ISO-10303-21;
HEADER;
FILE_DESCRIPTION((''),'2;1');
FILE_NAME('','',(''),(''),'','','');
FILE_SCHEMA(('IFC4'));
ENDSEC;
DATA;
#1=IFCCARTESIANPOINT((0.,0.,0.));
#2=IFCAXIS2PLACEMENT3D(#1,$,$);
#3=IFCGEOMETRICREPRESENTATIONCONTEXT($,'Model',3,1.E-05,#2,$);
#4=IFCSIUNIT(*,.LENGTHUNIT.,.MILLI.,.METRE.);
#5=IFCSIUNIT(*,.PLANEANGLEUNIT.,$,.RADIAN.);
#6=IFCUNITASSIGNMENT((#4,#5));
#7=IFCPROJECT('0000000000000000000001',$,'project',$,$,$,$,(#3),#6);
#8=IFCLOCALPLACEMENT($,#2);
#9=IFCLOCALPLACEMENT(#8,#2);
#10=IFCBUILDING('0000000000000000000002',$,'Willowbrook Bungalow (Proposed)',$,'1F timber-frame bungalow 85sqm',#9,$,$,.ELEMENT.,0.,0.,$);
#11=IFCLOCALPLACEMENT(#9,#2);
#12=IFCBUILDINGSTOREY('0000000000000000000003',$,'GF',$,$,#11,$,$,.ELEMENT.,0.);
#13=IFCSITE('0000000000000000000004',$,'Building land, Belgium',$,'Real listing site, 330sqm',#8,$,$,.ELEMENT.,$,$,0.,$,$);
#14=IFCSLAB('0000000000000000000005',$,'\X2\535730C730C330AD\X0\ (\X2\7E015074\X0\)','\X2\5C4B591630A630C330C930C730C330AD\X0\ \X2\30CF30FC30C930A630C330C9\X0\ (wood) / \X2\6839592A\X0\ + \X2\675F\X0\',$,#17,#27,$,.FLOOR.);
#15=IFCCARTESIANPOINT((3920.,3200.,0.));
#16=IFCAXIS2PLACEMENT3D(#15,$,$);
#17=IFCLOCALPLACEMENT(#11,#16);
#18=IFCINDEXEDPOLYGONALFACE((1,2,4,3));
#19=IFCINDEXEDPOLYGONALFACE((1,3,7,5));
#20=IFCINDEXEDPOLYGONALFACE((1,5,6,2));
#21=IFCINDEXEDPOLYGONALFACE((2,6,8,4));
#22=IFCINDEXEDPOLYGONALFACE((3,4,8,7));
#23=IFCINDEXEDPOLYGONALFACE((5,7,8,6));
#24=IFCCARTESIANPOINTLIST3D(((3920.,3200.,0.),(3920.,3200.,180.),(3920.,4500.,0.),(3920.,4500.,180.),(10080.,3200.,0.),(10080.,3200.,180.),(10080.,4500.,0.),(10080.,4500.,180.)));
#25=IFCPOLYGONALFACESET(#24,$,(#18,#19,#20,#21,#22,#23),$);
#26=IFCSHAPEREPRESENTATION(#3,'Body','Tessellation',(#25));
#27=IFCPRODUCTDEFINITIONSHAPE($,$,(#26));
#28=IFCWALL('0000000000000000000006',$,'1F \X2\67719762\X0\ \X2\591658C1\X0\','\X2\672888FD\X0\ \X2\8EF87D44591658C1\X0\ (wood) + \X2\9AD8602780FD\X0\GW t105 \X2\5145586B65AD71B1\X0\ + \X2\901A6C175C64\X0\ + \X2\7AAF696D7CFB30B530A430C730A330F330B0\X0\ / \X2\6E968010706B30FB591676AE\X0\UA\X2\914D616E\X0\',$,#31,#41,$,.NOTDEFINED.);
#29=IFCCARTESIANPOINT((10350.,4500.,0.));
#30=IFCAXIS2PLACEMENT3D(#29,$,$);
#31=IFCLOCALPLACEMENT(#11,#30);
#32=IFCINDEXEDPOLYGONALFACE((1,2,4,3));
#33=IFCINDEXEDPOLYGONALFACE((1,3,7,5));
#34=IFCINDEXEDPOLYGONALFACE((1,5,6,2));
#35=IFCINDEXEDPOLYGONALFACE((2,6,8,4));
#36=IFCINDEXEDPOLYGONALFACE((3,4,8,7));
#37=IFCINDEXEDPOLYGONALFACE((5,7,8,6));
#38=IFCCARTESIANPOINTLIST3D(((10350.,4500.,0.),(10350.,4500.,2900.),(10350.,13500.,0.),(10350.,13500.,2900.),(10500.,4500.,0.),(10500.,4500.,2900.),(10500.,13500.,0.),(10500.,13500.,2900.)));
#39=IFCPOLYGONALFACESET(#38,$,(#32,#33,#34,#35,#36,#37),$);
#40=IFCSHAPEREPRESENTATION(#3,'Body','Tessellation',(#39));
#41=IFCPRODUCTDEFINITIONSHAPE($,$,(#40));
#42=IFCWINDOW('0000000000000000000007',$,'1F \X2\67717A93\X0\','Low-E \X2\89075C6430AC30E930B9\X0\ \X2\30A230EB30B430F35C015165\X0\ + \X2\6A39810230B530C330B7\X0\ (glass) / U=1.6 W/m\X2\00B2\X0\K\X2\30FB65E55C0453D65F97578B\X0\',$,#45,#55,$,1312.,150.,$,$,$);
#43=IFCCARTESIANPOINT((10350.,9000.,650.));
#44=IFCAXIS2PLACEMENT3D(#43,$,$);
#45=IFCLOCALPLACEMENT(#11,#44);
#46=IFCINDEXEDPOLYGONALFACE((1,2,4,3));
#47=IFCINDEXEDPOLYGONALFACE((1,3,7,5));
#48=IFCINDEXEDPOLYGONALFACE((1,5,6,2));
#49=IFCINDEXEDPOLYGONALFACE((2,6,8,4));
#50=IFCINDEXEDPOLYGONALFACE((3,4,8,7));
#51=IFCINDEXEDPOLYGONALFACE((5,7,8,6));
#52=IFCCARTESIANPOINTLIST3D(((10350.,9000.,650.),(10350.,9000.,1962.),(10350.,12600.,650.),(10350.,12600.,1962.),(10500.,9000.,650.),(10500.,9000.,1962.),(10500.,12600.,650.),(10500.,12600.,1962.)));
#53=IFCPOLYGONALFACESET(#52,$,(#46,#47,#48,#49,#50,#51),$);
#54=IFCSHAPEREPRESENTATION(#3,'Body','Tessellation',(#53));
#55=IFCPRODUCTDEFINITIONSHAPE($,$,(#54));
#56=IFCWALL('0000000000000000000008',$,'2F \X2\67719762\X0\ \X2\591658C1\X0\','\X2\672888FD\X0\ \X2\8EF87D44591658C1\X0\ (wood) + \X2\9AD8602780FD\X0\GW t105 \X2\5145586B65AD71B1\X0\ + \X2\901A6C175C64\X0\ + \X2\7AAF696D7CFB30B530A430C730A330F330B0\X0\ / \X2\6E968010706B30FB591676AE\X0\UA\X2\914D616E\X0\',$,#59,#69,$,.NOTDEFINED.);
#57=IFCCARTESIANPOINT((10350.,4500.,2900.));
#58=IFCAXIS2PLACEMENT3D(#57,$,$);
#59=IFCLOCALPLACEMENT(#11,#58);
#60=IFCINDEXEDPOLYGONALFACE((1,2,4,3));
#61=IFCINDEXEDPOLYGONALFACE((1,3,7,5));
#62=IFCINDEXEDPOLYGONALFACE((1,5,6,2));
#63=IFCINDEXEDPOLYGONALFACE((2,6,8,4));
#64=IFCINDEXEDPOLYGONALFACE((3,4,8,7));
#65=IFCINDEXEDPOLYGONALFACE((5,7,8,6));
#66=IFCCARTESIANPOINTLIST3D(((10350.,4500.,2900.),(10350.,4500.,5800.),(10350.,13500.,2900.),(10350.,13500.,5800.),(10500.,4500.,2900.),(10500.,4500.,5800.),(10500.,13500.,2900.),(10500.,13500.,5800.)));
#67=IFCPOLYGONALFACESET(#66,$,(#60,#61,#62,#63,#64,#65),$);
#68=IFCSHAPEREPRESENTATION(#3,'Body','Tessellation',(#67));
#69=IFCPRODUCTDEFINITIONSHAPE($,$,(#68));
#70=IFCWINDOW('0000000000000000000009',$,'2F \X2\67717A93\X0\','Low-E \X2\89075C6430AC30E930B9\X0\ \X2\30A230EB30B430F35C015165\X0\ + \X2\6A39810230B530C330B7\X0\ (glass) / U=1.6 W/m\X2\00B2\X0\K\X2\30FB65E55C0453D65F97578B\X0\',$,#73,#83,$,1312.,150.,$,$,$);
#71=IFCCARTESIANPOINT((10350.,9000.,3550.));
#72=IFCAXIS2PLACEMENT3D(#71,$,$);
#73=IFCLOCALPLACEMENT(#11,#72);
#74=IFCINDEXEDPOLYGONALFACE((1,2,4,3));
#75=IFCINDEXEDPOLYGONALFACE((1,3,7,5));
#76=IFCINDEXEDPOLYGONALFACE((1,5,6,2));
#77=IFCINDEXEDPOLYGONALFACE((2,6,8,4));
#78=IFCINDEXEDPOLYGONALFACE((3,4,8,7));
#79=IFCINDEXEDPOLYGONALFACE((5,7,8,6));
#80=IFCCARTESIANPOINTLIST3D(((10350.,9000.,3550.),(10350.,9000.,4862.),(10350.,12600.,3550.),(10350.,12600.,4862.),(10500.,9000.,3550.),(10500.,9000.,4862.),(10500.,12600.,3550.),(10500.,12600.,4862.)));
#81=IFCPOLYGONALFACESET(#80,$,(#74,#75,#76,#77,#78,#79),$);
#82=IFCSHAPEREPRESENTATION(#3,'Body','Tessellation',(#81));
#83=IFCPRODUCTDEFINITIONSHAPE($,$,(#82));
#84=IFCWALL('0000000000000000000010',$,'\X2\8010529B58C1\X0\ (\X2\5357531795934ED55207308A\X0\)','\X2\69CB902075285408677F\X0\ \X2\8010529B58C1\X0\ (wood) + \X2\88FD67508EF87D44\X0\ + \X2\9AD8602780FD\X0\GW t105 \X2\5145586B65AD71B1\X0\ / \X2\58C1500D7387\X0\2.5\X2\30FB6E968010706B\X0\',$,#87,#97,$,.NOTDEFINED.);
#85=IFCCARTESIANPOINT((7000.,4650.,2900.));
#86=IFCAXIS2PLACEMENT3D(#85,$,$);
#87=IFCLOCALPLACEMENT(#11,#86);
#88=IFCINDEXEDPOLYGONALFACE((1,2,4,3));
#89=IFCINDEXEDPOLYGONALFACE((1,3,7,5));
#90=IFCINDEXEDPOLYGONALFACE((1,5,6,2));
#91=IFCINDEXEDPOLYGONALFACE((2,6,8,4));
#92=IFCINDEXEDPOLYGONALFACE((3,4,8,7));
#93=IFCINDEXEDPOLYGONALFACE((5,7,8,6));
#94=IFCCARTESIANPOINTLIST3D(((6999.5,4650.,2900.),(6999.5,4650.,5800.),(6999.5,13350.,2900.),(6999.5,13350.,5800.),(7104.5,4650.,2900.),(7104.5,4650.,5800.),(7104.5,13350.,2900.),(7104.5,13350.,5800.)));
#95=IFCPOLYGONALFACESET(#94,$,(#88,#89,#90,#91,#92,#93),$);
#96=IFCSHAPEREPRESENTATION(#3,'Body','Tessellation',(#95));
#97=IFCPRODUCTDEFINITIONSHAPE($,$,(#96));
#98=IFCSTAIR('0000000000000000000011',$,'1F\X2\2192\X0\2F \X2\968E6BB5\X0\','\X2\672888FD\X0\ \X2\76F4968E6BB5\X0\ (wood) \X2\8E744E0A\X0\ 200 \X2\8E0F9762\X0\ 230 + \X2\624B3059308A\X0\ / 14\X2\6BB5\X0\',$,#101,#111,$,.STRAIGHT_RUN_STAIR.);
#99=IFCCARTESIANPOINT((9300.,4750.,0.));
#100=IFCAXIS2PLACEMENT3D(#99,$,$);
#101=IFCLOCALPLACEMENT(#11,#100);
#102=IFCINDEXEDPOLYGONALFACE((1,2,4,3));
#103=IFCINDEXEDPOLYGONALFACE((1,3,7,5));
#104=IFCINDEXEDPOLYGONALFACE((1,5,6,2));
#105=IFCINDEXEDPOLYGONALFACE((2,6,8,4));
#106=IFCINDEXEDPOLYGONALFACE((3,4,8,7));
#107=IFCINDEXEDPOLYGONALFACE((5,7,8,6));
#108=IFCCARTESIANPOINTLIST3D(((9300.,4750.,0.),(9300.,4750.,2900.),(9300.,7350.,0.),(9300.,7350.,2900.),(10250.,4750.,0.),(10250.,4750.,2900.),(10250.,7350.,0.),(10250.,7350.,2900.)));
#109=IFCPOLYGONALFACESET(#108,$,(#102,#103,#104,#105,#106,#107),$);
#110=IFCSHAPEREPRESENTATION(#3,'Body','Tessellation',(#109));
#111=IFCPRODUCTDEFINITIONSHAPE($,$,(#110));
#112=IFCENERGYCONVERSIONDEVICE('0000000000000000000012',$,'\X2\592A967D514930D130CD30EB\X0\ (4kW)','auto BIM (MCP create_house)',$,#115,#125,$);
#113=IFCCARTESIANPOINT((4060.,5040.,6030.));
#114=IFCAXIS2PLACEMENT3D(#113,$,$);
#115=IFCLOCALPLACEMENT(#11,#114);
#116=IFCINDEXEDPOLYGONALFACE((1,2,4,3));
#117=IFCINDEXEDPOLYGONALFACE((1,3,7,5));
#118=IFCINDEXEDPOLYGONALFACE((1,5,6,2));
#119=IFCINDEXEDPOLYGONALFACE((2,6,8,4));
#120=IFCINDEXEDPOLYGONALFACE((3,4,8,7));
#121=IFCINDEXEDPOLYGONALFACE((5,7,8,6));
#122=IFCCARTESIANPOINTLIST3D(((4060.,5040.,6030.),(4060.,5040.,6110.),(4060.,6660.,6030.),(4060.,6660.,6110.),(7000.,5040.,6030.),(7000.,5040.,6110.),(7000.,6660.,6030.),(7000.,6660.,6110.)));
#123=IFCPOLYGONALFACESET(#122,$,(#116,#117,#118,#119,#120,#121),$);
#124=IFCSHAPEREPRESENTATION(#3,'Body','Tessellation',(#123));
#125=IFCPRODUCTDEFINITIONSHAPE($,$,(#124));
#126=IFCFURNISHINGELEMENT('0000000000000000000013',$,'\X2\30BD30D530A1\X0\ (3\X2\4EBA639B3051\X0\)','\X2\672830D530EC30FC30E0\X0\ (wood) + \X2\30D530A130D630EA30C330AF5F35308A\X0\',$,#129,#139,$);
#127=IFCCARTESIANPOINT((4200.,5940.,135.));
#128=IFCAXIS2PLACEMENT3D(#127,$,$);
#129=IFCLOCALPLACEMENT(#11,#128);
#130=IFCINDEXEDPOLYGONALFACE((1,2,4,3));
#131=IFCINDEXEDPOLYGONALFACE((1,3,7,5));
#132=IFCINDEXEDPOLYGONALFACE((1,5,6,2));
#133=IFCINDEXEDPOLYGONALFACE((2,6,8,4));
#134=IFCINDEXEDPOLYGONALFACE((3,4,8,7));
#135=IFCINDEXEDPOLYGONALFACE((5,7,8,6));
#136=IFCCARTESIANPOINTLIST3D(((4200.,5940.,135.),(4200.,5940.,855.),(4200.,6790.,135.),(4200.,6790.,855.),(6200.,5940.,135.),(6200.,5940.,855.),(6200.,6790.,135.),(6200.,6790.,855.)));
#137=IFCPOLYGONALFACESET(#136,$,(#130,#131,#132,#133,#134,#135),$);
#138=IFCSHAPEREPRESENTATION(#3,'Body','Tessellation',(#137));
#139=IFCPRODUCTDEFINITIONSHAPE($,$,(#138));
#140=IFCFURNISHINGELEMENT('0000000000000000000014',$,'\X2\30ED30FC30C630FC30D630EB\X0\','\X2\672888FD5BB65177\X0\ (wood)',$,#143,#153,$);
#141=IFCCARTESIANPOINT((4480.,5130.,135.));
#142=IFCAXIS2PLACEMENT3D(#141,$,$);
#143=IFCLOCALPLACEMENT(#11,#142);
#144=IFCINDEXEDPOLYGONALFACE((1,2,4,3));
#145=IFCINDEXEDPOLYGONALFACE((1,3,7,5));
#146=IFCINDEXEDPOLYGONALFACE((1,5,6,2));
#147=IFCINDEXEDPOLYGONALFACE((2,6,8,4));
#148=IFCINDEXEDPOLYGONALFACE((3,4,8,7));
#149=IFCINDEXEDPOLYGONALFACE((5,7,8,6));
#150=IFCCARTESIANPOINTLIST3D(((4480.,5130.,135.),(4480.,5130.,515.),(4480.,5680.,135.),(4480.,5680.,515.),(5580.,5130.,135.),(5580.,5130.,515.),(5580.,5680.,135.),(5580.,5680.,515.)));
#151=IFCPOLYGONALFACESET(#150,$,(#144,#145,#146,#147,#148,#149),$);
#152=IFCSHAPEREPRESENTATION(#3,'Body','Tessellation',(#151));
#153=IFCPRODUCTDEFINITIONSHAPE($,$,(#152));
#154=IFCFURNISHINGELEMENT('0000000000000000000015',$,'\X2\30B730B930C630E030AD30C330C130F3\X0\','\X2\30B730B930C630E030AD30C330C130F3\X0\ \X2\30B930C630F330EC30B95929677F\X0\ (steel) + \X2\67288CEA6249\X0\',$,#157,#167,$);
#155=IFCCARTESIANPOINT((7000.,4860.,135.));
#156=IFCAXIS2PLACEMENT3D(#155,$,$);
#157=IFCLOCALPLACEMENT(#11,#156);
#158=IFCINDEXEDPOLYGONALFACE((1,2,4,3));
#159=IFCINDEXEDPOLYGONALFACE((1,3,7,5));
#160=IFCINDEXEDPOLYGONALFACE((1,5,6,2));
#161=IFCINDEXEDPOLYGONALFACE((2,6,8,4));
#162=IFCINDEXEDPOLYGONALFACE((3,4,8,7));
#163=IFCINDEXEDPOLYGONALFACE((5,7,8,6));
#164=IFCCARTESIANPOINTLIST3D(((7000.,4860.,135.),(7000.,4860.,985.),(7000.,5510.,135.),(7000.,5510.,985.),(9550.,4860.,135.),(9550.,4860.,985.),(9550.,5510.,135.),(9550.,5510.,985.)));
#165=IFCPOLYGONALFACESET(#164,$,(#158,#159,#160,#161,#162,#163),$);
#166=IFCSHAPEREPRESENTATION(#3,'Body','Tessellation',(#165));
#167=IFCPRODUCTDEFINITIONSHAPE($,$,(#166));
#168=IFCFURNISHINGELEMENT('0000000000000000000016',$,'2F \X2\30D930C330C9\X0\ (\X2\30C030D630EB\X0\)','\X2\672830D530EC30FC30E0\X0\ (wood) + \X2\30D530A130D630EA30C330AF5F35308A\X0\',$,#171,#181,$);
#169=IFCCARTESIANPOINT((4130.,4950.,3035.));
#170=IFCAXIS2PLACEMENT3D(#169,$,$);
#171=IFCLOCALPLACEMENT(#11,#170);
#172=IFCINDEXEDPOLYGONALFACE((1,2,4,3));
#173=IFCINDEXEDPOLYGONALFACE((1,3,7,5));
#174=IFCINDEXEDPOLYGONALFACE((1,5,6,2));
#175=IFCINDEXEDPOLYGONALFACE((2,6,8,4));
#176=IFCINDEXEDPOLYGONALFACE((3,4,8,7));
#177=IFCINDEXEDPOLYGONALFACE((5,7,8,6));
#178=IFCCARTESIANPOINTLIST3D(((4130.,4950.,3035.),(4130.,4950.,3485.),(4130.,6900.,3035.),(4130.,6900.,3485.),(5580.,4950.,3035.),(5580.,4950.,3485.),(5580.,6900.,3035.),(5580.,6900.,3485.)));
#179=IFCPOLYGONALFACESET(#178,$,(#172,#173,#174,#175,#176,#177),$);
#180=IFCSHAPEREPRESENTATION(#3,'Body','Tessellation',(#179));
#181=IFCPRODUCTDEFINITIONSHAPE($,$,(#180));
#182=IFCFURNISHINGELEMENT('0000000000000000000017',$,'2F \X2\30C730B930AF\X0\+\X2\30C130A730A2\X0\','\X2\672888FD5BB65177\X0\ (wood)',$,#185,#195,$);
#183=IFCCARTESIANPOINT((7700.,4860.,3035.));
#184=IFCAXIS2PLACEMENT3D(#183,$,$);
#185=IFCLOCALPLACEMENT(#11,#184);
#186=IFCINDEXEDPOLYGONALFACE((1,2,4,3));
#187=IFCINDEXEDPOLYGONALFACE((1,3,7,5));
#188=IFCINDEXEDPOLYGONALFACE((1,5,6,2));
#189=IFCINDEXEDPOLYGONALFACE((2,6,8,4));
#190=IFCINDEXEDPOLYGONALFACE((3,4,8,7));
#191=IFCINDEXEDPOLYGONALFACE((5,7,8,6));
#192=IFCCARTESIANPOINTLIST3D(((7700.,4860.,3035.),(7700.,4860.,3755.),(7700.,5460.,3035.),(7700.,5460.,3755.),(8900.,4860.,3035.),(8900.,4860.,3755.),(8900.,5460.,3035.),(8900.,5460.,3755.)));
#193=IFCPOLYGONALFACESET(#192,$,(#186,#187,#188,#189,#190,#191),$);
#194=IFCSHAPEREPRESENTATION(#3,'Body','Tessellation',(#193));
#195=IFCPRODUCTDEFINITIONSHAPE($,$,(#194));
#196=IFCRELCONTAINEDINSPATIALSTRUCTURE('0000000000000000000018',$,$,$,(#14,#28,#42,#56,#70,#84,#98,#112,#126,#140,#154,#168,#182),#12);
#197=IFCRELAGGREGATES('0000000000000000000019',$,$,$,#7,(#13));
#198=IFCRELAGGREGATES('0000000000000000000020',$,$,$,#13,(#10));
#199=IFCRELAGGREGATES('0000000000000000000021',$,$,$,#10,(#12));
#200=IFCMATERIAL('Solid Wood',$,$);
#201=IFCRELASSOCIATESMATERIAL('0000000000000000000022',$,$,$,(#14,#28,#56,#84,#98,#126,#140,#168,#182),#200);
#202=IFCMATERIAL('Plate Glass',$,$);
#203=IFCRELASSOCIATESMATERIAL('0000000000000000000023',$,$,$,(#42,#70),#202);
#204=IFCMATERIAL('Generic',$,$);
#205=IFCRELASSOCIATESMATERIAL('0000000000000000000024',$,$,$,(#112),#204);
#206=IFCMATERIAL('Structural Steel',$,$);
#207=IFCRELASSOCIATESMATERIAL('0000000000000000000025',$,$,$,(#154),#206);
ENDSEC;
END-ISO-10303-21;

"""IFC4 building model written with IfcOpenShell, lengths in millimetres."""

from ifc_helpers import new_model, si_unit, frame, frame_2d, origin, place, context, project, spatial, rectangle, extrude, material, element, fill, save


model = new_model("IFC4")

# Units and contexts
model_context = context("Model", 3, precision=1e-05, world=origin())
ifc_project = project(units=[si_unit("LENGTHUNIT", "METRE", prefix="MILLI"), si_unit("PLANEANGLEUNIT", "RADIAN")], contexts=[model_context])

# Site, building, storey
site_placement = place(None, origin())
site = spatial("IfcSite", under=ifc_project, at=site_placement, Name="Building land, Belgium", ObjectType="Real listing site, 330sqm", CompositionType="ELEMENT", RefElevation=0.0)
building_placement = place(site_placement, origin())
building = spatial("IfcBuilding", under=site, at=building_placement, Name="Willowbrook Bungalow (Proposed)", ObjectType="1F timber-frame bungalow 85sqm", CompositionType="ELEMENT", ElevationOfRefHeight=0.0, ElevationOfTerrain=0.0)
storey_placement = place(building_placement, origin())
storey = spatial("IfcBuildingStorey", under=building, at=storey_placement, Name="GF", CompositionType="ELEMENT", Elevation=0.0)

# Slab
ifc_material_1 = material(Name="Solid Wood")
slab_placement = place(storey_placement, frame((3920.0, 3200.0, 0.0)))
element("IfcSlab", 1, at=slab_placement, inside=storey, material=ifc_material_1, Name="南デッキ (縁側)", Description="屋外ウッドデッキ ハードウッド (wood) / 根太 + 束", PredefinedType="FLOOR", context=model_context, shape_type="SweptSolid", body=[
    extrude(rectangle(XDim=6160.0, YDim=1300.0, at=frame_2d((3080.0, 650.0))), frame((3920.0, 3200.0, 0.0)), (0.0, 0.0, 1.0), 180.0),
])

# Wall, opening, window
wall_1_placement = place(storey_placement, frame((10350.0, 4500.0, 0.0)))
wall_1 = element("IfcWall", 2, at=wall_1_placement, inside=storey, material=ifc_material_1, Name="1F 東面 外壁", Description="木製 軸組外壁 (wood) + 高性能GW t105 充填断熱 + 通気層 + 窯業系サイディング / 準耐火・外皮UA配慮", PredefinedType="NOTDEFINED", context=model_context, shape_type="SweptSolid", body=[
    extrude(rectangle(XDim=150.0, YDim=9000.0, at=frame_2d((75.0, 4500.0))), frame((10350.0, 4500.0, 0.0)), (0.0, 0.0, 1.0), 2900.0),
])
opening_1_placement = place(storey_placement, frame((10350.0, 9000.0, 650.0)))
opening_1 = element("IfcOpeningElement", 3, at=opening_1_placement, cuts=wall_1, PredefinedType="NOTDEFINED", context=model_context, shape_type="SweptSolid", body=[
    extrude(rectangle(XDim=150.0, YDim=3600.0, at=frame_2d((75.0, 1800.0))), frame((10350.0, 9000.0, 650.0)), (0.0, 0.0, 1.0), 1312.0),
])
ifc_material_2 = material(Name="Plate Glass")
window_1_placement = place(storey_placement, frame((10350.0, 9000.0, 650.0)))
window_1 = element("IfcWindow", 4, at=window_1_placement, inside=storey, material=ifc_material_2, Name="1F 東窓", Description="Low-E 複層ガラス アルゴン封入 + 樹脂サッシ (glass) / U=1.6 W/m²K・日射取得型", OverallHeight=1312.0, OverallWidth=150.0, context=model_context, shape_type="SweptSolid", body=[
    extrude(rectangle(XDim=150.0, YDim=3600.0, at=frame_2d((75.0, 1800.0))), frame((10350.0, 9000.0, 650.0)), (0.0, 0.0, 1.0), 1312.0),
])
fill(opening_1, window_1)

# Wall, opening, window
wall_2_placement = place(storey_placement, frame((10350.0, 4500.0, 2900.0)))
wall_2 = element("IfcWall", 5, at=wall_2_placement, inside=storey, material=ifc_material_1, Name="2F 東面 外壁", Description="木製 軸組外壁 (wood) + 高性能GW t105 充填断熱 + 通気層 + 窯業系サイディング / 準耐火・外皮UA配慮", PredefinedType="NOTDEFINED", context=model_context, shape_type="SweptSolid", body=[
    extrude(rectangle(XDim=150.0, YDim=9000.0, at=frame_2d((75.0, 4500.0))), frame((10350.0, 4500.0, 2900.0)), (0.0, 0.0, 1.0), 2900.0),
])
opening_2_placement = place(storey_placement, frame((10350.0, 9000.0, 3550.0)))
opening_2 = element("IfcOpeningElement", 6, at=opening_2_placement, cuts=wall_2, PredefinedType="NOTDEFINED", context=model_context, shape_type="SweptSolid", body=[
    extrude(rectangle(XDim=150.0, YDim=3600.0, at=frame_2d((75.0, 1800.0))), frame((10350.0, 9000.0, 3550.0)), (0.0, 0.0, 1.0), 1312.0),
])
window_2_placement = place(storey_placement, frame((10350.0, 9000.0, 3550.0)))
window_2 = element("IfcWindow", 7, at=window_2_placement, inside=storey, material=ifc_material_2, Name="2F 東窓", Description="Low-E 複層ガラス アルゴン封入 + 樹脂サッシ (glass) / U=1.6 W/m²K・日射取得型", OverallHeight=1312.0, OverallWidth=150.0, context=model_context, shape_type="SweptSolid", body=[
    extrude(rectangle(XDim=150.0, YDim=3600.0, at=frame_2d((75.0, 1800.0))), frame((10350.0, 9000.0, 3550.0)), (0.0, 0.0, 1.0), 1312.0),
])
fill(opening_2, window_2)

# Wall
wall_3_placement = place(storey_placement, frame((7000.0, 4650.0, 2900.0)))
element("IfcWall", 8, at=wall_3_placement, inside=storey, material=ifc_material_1, Name="耐力壁 (南北間仕切り)", Description="構造用合板 耐力壁 (wood) + 製材軸組 + 高性能GW t105 充填断熱 / 壁倍率2.5・準耐火", PredefinedType="NOTDEFINED", context=model_context, shape_type="SweptSolid", body=[
    extrude(rectangle(XDim=105.0, YDim=8700.0, at=frame_2d((52.0, 4350.0))), frame((7000.0, 4650.0, 2900.0)), (0.0, 0.0, 1.0), 2900.0),
])

# Stair
stair_placement = place(storey_placement, frame((9300.0, 4750.0, 0.0)))
element("IfcStair", 9, at=stair_placement, inside=storey, material=ifc_material_1, Name="1F→2F 階段", Description="木製 直階段 (wood) 蹴上 200 踏面 230 + 手すり / 14段", PredefinedType="STRAIGHT_RUN_STAIR", context=model_context, shape_type="SweptSolid", body=[
    extrude(rectangle(XDim=950.0, YDim=2600.0, at=frame_2d((475.0, 1300.0))), frame((9300.0, 4750.0, 0.0)), (0.0, 0.0, 1.0), 2900.0),
])

# Energy conversion device
ifc_material_3 = material(Name="Generic")
energy_conversion_device_placement = place(storey_placement, frame((4060.0, 5040.0, 6030.0)))
element("IfcEnergyConversionDevice", 10, at=energy_conversion_device_placement, inside=storey, material=ifc_material_3, Name="太陽光パネル (4kW)", Description="auto BIM (MCP create_house)", context=model_context, shape_type="SweptSolid", body=[
    extrude(rectangle(XDim=2940.0, YDim=1620.0, at=frame_2d((1470.0, 810.0))), frame((4060.0, 5040.0, 6030.0)), (0.0, 0.0, 1.0), 80.0),
])

# Furnishing elements
furnishing_1_placement = place(storey_placement, frame((4200.0, 5940.0, 135.0)))
element("IfcFurnishingElement", 11, at=furnishing_1_placement, inside=storey, material=ifc_material_1, Name="ソファ (3人掛け)", Description="木フレーム (wood) + ファブリック張り", context=model_context, shape_type="SweptSolid", body=[
    extrude(rectangle(XDim=2000.0, YDim=850.0, at=frame_2d((1000.0, 425.0))), frame((4200.0, 5940.0, 135.0)), (0.0, 0.0, 1.0), 720.0),
])
furnishing_2_placement = place(storey_placement, frame((4480.0, 5130.0, 135.0)))
element("IfcFurnishingElement", 12, at=furnishing_2_placement, inside=storey, material=ifc_material_1, Name="ローテーブル", Description="木製家具 (wood)", context=model_context, shape_type="SweptSolid", body=[
    extrude(rectangle(XDim=1100.0, YDim=550.0, at=frame_2d((550.0, 275.0))), frame((4480.0, 5130.0, 135.0)), (0.0, 0.0, 1.0), 380.0),
])
ifc_material_4 = material(Name="Structural Steel")
furnishing_3_placement = place(storey_placement, frame((7000.0, 4860.0, 135.0)))
element("IfcFurnishingElement", 13, at=furnishing_3_placement, inside=storey, material=ifc_material_4, Name="システムキッチン", Description="システムキッチン ステンレス天板 (steel) + 木質扉", context=model_context, shape_type="SweptSolid", body=[
    extrude(rectangle(XDim=2550.0, YDim=650.0, at=frame_2d((1275.0, 325.0))), frame((7000.0, 4860.0, 135.0)), (0.0, 0.0, 1.0), 850.0),
])
furnishing_4_placement = place(storey_placement, frame((4130.0, 4950.0, 3035.0)))
element("IfcFurnishingElement", 14, at=furnishing_4_placement, inside=storey, material=ifc_material_1, Name="2F ベッド (ダブル)", Description="木フレーム (wood) + ファブリック張り", context=model_context, shape_type="SweptSolid", body=[
    extrude(rectangle(XDim=1450.0, YDim=1950.0, at=frame_2d((725.0, 975.0))), frame((4130.0, 4950.0, 3035.0)), (0.0, 0.0, 1.0), 450.0),
])
furnishing_5_placement = place(storey_placement, frame((7700.0, 4860.0, 3035.0)))
element("IfcFurnishingElement", 15, at=furnishing_5_placement, inside=storey, material=ifc_material_1, Name="2F デスク+チェア", Description="木製家具 (wood)", context=model_context, shape_type="SweptSolid", body=[
    extrude(rectangle(XDim=1200.0, YDim=600.0, at=frame_2d((600.0, 300.0))), frame((7700.0, 4860.0, 3035.0)), (0.0, 0.0, 1.0), 720.0),
])

save(model, "model.ifc")
